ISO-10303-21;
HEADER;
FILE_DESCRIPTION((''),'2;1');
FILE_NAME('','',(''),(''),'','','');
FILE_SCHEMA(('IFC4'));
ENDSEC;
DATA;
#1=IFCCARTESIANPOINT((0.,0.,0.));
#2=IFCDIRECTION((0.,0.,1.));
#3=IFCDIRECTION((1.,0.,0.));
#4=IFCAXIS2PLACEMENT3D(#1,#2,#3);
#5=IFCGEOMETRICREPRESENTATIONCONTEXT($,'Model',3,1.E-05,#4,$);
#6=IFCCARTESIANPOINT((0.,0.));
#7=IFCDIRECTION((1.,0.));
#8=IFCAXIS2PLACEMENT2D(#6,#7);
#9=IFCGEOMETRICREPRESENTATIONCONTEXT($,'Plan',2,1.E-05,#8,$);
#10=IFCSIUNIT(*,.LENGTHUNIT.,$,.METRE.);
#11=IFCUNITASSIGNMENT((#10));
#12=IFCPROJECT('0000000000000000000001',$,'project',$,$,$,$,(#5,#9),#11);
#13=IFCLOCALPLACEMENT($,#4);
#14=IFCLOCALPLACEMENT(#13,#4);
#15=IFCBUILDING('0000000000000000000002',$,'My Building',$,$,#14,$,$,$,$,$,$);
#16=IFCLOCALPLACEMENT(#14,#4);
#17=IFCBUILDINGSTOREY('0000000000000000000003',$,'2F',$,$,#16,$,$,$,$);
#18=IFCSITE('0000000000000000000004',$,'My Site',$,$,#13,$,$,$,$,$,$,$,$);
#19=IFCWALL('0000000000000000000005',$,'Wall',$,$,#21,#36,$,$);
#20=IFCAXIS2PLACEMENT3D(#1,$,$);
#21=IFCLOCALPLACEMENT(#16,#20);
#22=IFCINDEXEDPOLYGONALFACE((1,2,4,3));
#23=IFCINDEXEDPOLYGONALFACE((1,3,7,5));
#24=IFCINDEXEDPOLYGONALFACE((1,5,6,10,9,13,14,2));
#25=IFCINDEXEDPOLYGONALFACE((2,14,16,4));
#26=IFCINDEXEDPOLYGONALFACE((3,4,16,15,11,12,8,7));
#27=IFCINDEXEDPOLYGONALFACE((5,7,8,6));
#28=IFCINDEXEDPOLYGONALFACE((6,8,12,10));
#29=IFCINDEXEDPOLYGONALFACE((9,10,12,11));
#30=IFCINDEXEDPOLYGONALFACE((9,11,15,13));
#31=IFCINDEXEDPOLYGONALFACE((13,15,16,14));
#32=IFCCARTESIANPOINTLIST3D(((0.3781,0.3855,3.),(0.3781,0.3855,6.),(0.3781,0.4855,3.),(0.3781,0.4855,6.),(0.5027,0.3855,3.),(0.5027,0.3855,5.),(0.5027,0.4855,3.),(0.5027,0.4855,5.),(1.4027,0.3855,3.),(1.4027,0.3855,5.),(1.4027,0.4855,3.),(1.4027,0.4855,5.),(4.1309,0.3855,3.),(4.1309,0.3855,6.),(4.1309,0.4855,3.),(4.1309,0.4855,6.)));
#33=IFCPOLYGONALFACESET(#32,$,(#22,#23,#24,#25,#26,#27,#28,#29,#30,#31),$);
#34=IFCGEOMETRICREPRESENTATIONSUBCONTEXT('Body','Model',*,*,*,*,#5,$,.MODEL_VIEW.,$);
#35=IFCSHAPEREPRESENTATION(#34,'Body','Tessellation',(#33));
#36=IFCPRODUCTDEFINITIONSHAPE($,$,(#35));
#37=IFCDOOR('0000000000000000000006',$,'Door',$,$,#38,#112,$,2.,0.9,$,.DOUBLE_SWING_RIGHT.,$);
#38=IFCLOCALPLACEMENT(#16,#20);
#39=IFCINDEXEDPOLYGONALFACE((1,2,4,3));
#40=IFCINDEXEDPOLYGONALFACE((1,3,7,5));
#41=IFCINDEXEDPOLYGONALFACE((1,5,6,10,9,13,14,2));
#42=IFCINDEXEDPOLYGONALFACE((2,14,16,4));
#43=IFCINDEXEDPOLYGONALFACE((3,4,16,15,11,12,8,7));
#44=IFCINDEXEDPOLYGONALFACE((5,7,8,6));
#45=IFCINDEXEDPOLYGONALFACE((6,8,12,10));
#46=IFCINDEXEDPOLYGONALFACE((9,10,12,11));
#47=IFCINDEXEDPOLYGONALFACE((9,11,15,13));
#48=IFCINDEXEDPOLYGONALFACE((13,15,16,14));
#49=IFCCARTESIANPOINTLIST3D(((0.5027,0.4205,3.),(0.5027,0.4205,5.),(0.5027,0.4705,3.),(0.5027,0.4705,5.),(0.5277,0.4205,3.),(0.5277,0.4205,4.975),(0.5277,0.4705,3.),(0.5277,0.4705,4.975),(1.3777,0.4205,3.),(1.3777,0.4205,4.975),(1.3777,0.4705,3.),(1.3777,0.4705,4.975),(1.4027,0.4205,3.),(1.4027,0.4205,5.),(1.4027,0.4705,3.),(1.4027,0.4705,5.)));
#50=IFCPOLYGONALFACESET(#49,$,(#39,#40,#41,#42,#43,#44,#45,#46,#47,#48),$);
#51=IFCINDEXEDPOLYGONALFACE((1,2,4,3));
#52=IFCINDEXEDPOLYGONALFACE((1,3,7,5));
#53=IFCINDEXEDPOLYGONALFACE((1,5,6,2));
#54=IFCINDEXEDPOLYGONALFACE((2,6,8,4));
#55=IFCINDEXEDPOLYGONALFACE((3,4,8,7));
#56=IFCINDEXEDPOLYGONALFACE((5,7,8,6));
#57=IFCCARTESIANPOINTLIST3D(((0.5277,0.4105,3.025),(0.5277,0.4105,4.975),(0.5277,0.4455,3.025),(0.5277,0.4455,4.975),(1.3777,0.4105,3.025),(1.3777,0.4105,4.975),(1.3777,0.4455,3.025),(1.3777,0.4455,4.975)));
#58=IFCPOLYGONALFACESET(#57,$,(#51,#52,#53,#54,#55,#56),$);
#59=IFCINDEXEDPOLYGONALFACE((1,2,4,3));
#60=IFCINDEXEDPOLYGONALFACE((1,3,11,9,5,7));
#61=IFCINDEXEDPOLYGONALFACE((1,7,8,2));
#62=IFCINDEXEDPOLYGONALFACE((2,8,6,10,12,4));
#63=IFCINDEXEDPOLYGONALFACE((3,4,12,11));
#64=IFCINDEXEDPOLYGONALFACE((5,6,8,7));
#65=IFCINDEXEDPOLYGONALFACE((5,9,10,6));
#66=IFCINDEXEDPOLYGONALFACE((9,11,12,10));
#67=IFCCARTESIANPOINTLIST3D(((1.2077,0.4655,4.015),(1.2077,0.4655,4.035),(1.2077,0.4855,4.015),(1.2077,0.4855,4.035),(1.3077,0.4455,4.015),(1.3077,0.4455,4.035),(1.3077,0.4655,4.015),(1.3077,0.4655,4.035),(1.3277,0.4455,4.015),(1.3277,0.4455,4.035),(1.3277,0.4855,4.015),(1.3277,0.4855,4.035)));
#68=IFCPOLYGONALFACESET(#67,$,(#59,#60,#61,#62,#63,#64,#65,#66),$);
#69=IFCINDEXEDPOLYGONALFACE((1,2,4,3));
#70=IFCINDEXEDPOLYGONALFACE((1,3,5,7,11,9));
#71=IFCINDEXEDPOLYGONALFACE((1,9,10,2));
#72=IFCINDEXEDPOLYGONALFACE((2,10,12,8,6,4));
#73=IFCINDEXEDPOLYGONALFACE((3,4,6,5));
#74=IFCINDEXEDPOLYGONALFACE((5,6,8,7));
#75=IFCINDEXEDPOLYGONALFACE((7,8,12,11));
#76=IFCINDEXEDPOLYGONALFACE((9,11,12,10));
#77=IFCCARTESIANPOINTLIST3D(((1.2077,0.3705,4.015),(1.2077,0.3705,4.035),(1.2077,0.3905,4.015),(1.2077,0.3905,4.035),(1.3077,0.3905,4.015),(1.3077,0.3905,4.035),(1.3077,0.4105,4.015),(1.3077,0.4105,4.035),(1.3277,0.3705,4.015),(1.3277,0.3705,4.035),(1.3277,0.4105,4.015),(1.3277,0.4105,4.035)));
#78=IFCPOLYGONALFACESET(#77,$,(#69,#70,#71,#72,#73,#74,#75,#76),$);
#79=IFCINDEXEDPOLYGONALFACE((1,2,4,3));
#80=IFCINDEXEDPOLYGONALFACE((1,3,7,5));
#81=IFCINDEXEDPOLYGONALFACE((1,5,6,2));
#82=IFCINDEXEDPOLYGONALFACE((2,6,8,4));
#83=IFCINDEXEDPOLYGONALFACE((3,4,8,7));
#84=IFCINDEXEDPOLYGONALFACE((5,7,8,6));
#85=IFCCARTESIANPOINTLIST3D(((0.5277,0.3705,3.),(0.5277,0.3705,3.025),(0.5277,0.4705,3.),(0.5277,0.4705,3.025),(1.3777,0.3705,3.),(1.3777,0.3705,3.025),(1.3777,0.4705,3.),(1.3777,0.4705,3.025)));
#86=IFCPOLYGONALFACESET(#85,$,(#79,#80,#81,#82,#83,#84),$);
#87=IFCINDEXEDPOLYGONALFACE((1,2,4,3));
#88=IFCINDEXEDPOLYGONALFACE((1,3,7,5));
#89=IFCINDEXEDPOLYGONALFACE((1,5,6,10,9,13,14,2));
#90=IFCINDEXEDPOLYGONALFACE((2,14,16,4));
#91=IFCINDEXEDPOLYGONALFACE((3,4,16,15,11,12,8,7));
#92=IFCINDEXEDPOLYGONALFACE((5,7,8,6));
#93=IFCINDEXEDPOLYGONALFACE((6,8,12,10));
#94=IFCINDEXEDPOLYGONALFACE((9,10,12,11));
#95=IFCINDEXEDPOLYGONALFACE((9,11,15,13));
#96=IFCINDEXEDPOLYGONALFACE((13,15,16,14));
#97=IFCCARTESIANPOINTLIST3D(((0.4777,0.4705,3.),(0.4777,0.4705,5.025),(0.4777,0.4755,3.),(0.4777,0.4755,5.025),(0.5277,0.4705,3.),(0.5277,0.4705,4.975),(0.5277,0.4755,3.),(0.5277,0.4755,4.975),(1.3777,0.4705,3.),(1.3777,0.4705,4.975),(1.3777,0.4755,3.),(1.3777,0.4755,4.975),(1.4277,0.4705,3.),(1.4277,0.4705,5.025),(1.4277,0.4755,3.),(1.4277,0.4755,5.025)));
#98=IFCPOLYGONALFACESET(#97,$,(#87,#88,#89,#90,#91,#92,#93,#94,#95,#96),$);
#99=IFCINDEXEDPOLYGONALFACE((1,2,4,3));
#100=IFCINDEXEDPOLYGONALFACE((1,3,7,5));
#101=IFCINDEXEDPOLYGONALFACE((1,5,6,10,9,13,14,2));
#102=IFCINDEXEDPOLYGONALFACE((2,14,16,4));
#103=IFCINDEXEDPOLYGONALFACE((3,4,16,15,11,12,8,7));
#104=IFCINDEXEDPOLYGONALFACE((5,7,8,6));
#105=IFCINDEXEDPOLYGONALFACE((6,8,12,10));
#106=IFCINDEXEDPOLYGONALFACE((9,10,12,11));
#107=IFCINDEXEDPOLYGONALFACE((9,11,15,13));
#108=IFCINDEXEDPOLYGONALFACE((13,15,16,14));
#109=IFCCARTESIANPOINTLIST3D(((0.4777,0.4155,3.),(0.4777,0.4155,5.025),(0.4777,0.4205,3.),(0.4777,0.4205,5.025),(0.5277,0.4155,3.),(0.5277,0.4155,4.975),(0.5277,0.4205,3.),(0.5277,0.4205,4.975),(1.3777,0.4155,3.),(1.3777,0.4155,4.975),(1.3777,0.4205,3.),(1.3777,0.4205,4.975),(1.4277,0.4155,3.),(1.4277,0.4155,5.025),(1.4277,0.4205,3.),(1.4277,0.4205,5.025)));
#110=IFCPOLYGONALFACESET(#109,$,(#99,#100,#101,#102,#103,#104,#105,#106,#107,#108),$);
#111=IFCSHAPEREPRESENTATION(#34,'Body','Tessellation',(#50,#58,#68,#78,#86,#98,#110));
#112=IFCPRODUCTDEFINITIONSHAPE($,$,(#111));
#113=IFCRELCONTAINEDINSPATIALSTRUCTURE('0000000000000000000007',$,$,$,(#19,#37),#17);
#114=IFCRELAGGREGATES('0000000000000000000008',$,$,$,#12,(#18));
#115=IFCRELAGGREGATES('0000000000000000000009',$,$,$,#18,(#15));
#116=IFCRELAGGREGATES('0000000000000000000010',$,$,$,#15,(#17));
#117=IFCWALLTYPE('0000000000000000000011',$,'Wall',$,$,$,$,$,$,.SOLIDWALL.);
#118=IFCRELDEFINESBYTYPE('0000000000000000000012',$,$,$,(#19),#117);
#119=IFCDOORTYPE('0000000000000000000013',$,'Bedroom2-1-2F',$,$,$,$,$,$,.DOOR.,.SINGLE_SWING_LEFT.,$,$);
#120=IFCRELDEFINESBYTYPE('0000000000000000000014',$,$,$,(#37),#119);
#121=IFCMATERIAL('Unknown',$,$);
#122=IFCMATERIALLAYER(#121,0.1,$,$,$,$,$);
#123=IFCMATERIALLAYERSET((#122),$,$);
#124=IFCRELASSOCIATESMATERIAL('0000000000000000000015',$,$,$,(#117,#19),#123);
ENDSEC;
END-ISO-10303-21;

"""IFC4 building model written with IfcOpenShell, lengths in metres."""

from ifc_helpers import new_model, entity, si_unit, frame, origin_with_axes, origin_2d_with_axis, place, context, subcontext, project, spatial, line, indexed_curve, outline, extrude, shape, source, transform, mapped, material, layer, layer_set, layer_usage, type_object, type_shapes, element, fill, save


model = new_model("IFC4")

# Units and contexts
model_context = context("Model", 3, precision=1e-05, world=origin_with_axes())
plan_context = context("Plan", 2, precision=1e-05, world=origin_2d_with_axis())
body_context_1 = subcontext(model_context, "Body", "Model", "MODEL_VIEW")
body_context_2 = subcontext(plan_context, "Body", "Plan", "PLAN_VIEW")
ifc_project = project(units=[si_unit("LENGTHUNIT", "METRE")], contexts=[model_context, plan_context])

# Site, building, storey
site_placement = place(None, origin_with_axes())
site = spatial("IfcSite", under=ifc_project, at=site_placement, Name="My Site")
building_placement = place(site_placement, origin_with_axes())
building = spatial("IfcBuilding", under=site, at=building_placement, Name="My Building")
storey_placement = place(building_placement, origin_with_axes())
storey = spatial("IfcBuildingStorey", under=building, at=storey_placement, Name="2F")

# Shared definitions
ifc_material = material(Name="Unknown")

# Shared definitions
ifc_layer = layer(ifc_material, 0.1)
ifc_layer_set = layer_set([ifc_layer])
wall_type = type_object("IfcWallType", Name="Wall", PredefinedType="SOLIDWALL", material=ifc_layer_set)

# Wall, opening, door
ifc_layer_usage_1 = layer_usage(ifc_layer_set, "AXIS2", "POSITIVE", 0.0)
wall_1_placement = place(storey_placement, frame((0.3781, 0.3855, 3.0), z_axis=(0.0, 0.0, 1.0), x_axis=(1.0, 0.0, 0.0)))
wall_1 = element("IfcWall", 1, at=wall_1_placement, inside=storey, type_object=wall_type, material=ifc_layer_usage_1, Name="Wall", context=body_context_1, shape_type="SweptSolid", body=[
    extrude(outline(indexed_curve([(0.0, 0.0), (0.0, 0.1), (3.7528, 0.1), (3.7528, 0.0)], segments=[line(1, 2, 3, 4, 1)])), origin_with_axes(), (0.0, 0.0, 1.0), 3.0),
])
shared_shape_1 = source(origin_with_axes(), body_context_1, "Body", "SweptSolid", [
    extrude(outline(indexed_curve([(0.0, 0.0), (0.9, 0.0), (0.9, 2.0), (0.0, 2.0)], segments=[line(1, 2, 3, 4, 1)])), frame((0.0, -0.6, 0.0), z_axis=(0.0, -1.0, 0.0), x_axis=(1.0, 0.0, 0.0)), (0.0, 0.0, -1.0), 1.2),
])
opening_1_placement = place(wall_1_placement, frame((1.0245, 0.085, 0.0), z_axis=(0.0, 0.0, 1.0), x_axis=(-1.0, 0.0, 0.0)))
opening_1 = element("IfcOpeningElement", 2, at=opening_1_placement, cuts=wall_1, PredefinedType="OPENING", context=body_context_1, shape_type="MappedRepresentation", body=[
    mapped(shared_shape_1, transform((0.0, 0.0, 0.0), x_axis=(1.0, 0.0, 0.0), y_axis=(0.0, 1.0, 0.0), z_axis=(0.0, 0.0, 1.0), scale=1.0)),
])
door_type_1 = type_object("IfcDoorType", Name="Bedroom2-1-2F", OperationType="SINGLE_SWING_LEFT", PredefinedType="DOOR")
shared_shape_2 = source(origin_with_axes(), body_context_1, "Body", "SweptSolid", [
    extrude(outline(indexed_curve([(0.0, 0.0), (0.0, 2.0), (0.9, 2.0), (0.9, 0.0), (0.875, 0.0), (0.875, 1.975), (0.025, 1.975), (0.025, 0.0)], segments=[line(1, 2, 3, 4, 5, 6, 7, 8, 1)])), frame((0.0, 0.0, 0.0), z_axis=(0.0, -1.0, 0.0), x_axis=(1.0, 0.0, 0.0)), (0.0, 0.0, -1.0), 0.05),
    extrude(outline(indexed_curve([(0.0, 0.0), (0.85, 0.0), (0.85, 0.035), (0.0, 0.035)], segments=[line(1, 2, 3, 4, 1)])), frame((0.025, 0.025, 0.025), z_axis=(0.0, 0.0, 1.0), x_axis=(1.0, 0.0, 0.0)), (0.0, 0.0, 1.0), 1.95),
    extrude(outline(indexed_curve([(0.0, 0.0), (0.0, -0.04), (0.12, -0.04), (0.12, -0.02), (0.02, -0.02), (0.02, 0.0)], segments=[line(1, 2, 3, 4, 5, 6, 1)])), frame((0.075, 0.025, 1.015), z_axis=(0.0, 0.0, 1.0), x_axis=(1.0, 0.0, 0.0)), (0.0, 0.0, 1.0), 0.02),
    extrude(outline(indexed_curve([(0.0, 0.0), (0.0, 0.04), (0.12, 0.04), (0.12, 0.02), (0.02, 0.02), (0.02, 0.0)], segments=[line(1, 2, 3, 4, 5, 6, 1)])), frame((0.075, 0.06, 1.015), z_axis=(0.0, 0.0, 1.0), x_axis=(1.0, 0.0, 0.0)), (0.0, 0.0, 1.0), 0.02),
    extrude(outline(indexed_curve([(0.0, 0.0), (0.85, 0.0), (0.85, 0.1), (0.0, 0.1)], segments=[line(1, 2, 3, 4, 1)])), frame((0.025, 0.0, 0.0), z_axis=(0.0, 0.0, 1.0), x_axis=(1.0, 0.0, 0.0)), (0.0, 0.0, 1.0), 0.025),
    extrude(outline(indexed_curve([(0.0, 0.0), (0.0, 2.025), (0.95, 2.025), (0.95, 0.0), (0.9, 0.0), (0.9, 1.975), (0.05, 1.975), (0.05, 0.0)], segments=[line(1, 2, 3, 4, 5, 6, 7, 8, 1)])), frame((-0.025, -0.005, 0.0), z_axis=(0.0, -1.0, 0.0), x_axis=(1.0, 0.0, 0.0)), (0.0, 0.0, -1.0), 0.005),
    extrude(outline(indexed_curve([(0.0, 0.0), (0.0, 2.025), (0.95, 2.025), (0.95, 0.0), (0.9, 0.0), (0.9, 1.975), (0.05, 1.975), (0.05, 0.0)], segments=[line(1, 2, 3, 4, 5, 6, 7, 8, 1)])), frame((-0.025, 0.05, 0.0), z_axis=(0.0, -1.0, 0.0), x_axis=(1.0, 0.0, 0.0)), (0.0, 0.0, -1.0), 0.005),
])
shared_shape_3 = source(origin_with_axes(), body_context_2, "Body", "Curve2D", [
    entity("IfcIndexedPolyCurve", entity("IfcCartesianPointList2D", [[0.0, 0.0], [0.025, 0.0], [0.025, 0.05], [0.0, 0.05]]), [entity("IfcLineIndex", [1, 2, 3, 4, 1])]),
    entity("IfcIndexedPolyCurve", entity("IfcCartesianPointList2D", [[0.9, 0.0], [0.875, 0.0], [0.875, 0.05], [0.9, 0.05]]), [entity("IfcLineIndex", [1, 2, 3, 4, 1])]),
    entity("IfcIndexedPolyCurve", entity("IfcCartesianPointList2D", [[0.875, 0.05], [0.875, -0.8], [0.84, -0.8]])),
    entity("IfcTrimmedCurve", entity("IfcEllipse", entity("IfcAxis2Placement2D", entity("IfcCartesianPoint", [0.84, 0.05]), entity("IfcDirection", [1.0, 0.0])), 0.815, 0.85), [entity("IfcCartesianPoint", [0.84, 0.9])], [entity("IfcCartesianPoint", [0.84, -0.8])], True, "CARTESIAN"),
    entity("IfcIndexedPolyCurve", entity("IfcCartesianPointList2D", [[0.875, 0.05], [0.84, 0.05], [0.84, 0.9], [0.875, 0.9]]), [entity("IfcLineIndex", [1, 2, 3, 4, 1])]),
])
type_shapes(door_type_1, [shared_shape_2, shared_shape_3])
door_1_placement = place(opening_1_placement, origin_with_axes())
door_1 = element("IfcDoor", 3, at=door_1_placement, inside=storey, type_object=door_type_1, Name="Door", OperationType="DOUBLE_SWING_RIGHT", OverallHeight=2.0, OverallWidth=0.9, shapes=[
    shape(body_context_1, "Body", "MappedRepresentation", [mapped(shared_shape_2, transform((0.0, 0.0, 0.0), x_axis=(1.0, 0.0, 0.0), y_axis=(0.0, 1.0, 0.0), z_axis=(0.0, 0.0, 1.0), scale=1.0))]),
    shape(body_context_2, "Body", "MappedRepresentation", [mapped(shared_shape_3, transform((0.0, 0.0, 0.0), x_axis=(1.0, 0.0, 0.0), y_axis=(0.0, 1.0, 0.0), z_axis=(0.0, 0.0, 1.0), scale=1.0))]),
])
fill(opening_1, door_1)

save(model, "model.ifc")
